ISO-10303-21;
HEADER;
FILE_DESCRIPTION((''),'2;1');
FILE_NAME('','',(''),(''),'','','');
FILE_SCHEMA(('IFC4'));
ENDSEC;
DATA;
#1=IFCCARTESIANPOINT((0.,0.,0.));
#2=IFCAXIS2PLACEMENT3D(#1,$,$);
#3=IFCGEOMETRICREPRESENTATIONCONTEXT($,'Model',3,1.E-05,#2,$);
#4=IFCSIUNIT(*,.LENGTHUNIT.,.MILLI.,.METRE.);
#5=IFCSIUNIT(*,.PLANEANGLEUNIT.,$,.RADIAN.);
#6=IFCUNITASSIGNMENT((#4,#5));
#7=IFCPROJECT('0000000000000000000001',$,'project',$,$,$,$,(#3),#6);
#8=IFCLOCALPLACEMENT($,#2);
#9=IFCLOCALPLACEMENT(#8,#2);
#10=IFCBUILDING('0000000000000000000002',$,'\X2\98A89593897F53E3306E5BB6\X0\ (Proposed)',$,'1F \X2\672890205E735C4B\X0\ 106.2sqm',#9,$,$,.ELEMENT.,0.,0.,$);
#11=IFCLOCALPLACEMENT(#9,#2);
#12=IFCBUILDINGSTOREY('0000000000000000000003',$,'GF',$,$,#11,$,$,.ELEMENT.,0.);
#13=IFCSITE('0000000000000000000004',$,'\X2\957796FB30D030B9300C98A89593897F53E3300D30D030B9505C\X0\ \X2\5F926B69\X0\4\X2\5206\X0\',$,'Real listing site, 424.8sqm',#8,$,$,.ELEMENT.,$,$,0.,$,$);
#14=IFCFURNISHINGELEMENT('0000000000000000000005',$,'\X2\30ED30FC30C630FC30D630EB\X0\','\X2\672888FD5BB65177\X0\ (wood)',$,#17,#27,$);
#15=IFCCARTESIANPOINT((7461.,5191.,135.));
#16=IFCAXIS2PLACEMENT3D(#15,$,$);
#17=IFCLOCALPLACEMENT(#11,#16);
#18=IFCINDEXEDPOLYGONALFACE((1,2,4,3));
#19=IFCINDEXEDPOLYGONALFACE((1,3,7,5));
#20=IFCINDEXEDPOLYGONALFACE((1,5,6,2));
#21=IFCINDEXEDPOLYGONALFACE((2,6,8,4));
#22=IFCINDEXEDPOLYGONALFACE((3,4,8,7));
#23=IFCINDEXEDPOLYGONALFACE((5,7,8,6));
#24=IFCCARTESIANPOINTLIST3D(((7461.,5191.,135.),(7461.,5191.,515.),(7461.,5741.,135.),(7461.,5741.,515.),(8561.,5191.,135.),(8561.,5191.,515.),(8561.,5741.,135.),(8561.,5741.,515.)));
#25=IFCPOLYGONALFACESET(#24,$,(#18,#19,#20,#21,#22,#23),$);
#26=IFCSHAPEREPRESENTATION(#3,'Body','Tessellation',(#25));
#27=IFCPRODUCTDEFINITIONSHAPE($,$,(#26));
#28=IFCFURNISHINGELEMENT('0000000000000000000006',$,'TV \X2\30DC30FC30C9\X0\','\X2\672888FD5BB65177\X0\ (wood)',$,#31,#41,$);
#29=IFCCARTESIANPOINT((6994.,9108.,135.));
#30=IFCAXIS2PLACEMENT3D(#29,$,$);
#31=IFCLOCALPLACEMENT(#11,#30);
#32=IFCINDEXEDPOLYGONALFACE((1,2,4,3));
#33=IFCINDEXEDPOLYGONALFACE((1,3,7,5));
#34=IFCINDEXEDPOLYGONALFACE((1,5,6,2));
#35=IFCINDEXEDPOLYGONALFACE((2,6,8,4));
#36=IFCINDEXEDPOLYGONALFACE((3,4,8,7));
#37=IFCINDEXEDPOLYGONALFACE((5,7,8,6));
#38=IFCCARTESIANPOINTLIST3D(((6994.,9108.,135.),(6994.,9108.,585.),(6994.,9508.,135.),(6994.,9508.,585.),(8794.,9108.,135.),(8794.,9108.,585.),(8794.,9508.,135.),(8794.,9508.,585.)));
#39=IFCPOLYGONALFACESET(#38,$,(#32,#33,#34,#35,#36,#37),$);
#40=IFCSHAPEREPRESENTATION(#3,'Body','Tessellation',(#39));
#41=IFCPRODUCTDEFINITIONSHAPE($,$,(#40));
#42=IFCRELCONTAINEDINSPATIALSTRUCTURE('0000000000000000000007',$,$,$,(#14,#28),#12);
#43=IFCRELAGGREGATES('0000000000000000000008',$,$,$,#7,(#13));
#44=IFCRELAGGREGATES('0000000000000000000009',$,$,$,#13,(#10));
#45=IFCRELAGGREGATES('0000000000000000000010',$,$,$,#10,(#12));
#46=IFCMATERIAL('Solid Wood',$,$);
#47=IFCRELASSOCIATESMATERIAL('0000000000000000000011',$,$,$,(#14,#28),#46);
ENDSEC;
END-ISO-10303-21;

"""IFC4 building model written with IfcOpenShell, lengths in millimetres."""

from ifc_helpers import new_model, si_unit, frame, frame_2d, origin, place, context, project, spatial, rectangle, extrude, material, element, save


model = new_model("IFC4")

# Units and contexts
model_context = context("Model", 3, precision=1e-05, world=origin())
ifc_project = project(units=[si_unit("LENGTHUNIT", "METRE", prefix="MILLI"), si_unit("PLANEANGLEUNIT", "RADIAN")], contexts=[model_context])

# Site, building, storey
site_placement = place(None, origin())
site = spatial("IfcSite", under=ifc_project, at=site_placement, Name="長電バス「風間西口」バス停 徒歩4分", ObjectType="Real listing site, 424.8sqm", CompositionType="ELEMENT", RefElevation=0.0)
building_placement = place(site_placement, origin())
building = spatial("IfcBuilding", under=site, at=building_placement, Name="風間西口の家 (Proposed)", ObjectType="1F 木造平屋 106.2sqm", CompositionType="ELEMENT", ElevationOfRefHeight=0.0, ElevationOfTerrain=0.0)
storey_placement = place(building_placement, origin())
storey = spatial("IfcBuildingStorey", under=building, at=storey_placement, Name="GF", CompositionType="ELEMENT", Elevation=0.0)

# Shared definitions
ifc_material_1 = material(Name="Solid Wood")

# Furnishing elements
furnishing_1_placement = place(storey_placement, frame((7461.0, 5191.0, 135.0)))
element("IfcFurnishingElement", 1, at=furnishing_1_placement, inside=storey, material=ifc_material_1, Name="ローテーブル", Description="木製家具 (wood)", context=model_context, shape_type="SweptSolid", body=[
    extrude(rectangle(XDim=1100.0, YDim=550.0, at=frame_2d((550.0, 275.0))), frame((7461.0, 5191.0, 135.0)), (0.0, 0.0, 1.0), 380.0),
])
furnishing_2_placement = place(storey_placement, frame((6994.0, 9108.0, 135.0)))
element("IfcFurnishingElement", 2, at=furnishing_2_placement, inside=storey, material=ifc_material_1, Name="TV ボード", Description="木製家具 (wood)", context=model_context, shape_type="SweptSolid", body=[
    extrude(rectangle(XDim=1800.0, YDim=400.0, at=frame_2d((900.0, 200.0))), frame((6994.0, 9108.0, 135.0)), (0.0, 0.0, 1.0), 450.0),
])

save(model, "model.ifc")
